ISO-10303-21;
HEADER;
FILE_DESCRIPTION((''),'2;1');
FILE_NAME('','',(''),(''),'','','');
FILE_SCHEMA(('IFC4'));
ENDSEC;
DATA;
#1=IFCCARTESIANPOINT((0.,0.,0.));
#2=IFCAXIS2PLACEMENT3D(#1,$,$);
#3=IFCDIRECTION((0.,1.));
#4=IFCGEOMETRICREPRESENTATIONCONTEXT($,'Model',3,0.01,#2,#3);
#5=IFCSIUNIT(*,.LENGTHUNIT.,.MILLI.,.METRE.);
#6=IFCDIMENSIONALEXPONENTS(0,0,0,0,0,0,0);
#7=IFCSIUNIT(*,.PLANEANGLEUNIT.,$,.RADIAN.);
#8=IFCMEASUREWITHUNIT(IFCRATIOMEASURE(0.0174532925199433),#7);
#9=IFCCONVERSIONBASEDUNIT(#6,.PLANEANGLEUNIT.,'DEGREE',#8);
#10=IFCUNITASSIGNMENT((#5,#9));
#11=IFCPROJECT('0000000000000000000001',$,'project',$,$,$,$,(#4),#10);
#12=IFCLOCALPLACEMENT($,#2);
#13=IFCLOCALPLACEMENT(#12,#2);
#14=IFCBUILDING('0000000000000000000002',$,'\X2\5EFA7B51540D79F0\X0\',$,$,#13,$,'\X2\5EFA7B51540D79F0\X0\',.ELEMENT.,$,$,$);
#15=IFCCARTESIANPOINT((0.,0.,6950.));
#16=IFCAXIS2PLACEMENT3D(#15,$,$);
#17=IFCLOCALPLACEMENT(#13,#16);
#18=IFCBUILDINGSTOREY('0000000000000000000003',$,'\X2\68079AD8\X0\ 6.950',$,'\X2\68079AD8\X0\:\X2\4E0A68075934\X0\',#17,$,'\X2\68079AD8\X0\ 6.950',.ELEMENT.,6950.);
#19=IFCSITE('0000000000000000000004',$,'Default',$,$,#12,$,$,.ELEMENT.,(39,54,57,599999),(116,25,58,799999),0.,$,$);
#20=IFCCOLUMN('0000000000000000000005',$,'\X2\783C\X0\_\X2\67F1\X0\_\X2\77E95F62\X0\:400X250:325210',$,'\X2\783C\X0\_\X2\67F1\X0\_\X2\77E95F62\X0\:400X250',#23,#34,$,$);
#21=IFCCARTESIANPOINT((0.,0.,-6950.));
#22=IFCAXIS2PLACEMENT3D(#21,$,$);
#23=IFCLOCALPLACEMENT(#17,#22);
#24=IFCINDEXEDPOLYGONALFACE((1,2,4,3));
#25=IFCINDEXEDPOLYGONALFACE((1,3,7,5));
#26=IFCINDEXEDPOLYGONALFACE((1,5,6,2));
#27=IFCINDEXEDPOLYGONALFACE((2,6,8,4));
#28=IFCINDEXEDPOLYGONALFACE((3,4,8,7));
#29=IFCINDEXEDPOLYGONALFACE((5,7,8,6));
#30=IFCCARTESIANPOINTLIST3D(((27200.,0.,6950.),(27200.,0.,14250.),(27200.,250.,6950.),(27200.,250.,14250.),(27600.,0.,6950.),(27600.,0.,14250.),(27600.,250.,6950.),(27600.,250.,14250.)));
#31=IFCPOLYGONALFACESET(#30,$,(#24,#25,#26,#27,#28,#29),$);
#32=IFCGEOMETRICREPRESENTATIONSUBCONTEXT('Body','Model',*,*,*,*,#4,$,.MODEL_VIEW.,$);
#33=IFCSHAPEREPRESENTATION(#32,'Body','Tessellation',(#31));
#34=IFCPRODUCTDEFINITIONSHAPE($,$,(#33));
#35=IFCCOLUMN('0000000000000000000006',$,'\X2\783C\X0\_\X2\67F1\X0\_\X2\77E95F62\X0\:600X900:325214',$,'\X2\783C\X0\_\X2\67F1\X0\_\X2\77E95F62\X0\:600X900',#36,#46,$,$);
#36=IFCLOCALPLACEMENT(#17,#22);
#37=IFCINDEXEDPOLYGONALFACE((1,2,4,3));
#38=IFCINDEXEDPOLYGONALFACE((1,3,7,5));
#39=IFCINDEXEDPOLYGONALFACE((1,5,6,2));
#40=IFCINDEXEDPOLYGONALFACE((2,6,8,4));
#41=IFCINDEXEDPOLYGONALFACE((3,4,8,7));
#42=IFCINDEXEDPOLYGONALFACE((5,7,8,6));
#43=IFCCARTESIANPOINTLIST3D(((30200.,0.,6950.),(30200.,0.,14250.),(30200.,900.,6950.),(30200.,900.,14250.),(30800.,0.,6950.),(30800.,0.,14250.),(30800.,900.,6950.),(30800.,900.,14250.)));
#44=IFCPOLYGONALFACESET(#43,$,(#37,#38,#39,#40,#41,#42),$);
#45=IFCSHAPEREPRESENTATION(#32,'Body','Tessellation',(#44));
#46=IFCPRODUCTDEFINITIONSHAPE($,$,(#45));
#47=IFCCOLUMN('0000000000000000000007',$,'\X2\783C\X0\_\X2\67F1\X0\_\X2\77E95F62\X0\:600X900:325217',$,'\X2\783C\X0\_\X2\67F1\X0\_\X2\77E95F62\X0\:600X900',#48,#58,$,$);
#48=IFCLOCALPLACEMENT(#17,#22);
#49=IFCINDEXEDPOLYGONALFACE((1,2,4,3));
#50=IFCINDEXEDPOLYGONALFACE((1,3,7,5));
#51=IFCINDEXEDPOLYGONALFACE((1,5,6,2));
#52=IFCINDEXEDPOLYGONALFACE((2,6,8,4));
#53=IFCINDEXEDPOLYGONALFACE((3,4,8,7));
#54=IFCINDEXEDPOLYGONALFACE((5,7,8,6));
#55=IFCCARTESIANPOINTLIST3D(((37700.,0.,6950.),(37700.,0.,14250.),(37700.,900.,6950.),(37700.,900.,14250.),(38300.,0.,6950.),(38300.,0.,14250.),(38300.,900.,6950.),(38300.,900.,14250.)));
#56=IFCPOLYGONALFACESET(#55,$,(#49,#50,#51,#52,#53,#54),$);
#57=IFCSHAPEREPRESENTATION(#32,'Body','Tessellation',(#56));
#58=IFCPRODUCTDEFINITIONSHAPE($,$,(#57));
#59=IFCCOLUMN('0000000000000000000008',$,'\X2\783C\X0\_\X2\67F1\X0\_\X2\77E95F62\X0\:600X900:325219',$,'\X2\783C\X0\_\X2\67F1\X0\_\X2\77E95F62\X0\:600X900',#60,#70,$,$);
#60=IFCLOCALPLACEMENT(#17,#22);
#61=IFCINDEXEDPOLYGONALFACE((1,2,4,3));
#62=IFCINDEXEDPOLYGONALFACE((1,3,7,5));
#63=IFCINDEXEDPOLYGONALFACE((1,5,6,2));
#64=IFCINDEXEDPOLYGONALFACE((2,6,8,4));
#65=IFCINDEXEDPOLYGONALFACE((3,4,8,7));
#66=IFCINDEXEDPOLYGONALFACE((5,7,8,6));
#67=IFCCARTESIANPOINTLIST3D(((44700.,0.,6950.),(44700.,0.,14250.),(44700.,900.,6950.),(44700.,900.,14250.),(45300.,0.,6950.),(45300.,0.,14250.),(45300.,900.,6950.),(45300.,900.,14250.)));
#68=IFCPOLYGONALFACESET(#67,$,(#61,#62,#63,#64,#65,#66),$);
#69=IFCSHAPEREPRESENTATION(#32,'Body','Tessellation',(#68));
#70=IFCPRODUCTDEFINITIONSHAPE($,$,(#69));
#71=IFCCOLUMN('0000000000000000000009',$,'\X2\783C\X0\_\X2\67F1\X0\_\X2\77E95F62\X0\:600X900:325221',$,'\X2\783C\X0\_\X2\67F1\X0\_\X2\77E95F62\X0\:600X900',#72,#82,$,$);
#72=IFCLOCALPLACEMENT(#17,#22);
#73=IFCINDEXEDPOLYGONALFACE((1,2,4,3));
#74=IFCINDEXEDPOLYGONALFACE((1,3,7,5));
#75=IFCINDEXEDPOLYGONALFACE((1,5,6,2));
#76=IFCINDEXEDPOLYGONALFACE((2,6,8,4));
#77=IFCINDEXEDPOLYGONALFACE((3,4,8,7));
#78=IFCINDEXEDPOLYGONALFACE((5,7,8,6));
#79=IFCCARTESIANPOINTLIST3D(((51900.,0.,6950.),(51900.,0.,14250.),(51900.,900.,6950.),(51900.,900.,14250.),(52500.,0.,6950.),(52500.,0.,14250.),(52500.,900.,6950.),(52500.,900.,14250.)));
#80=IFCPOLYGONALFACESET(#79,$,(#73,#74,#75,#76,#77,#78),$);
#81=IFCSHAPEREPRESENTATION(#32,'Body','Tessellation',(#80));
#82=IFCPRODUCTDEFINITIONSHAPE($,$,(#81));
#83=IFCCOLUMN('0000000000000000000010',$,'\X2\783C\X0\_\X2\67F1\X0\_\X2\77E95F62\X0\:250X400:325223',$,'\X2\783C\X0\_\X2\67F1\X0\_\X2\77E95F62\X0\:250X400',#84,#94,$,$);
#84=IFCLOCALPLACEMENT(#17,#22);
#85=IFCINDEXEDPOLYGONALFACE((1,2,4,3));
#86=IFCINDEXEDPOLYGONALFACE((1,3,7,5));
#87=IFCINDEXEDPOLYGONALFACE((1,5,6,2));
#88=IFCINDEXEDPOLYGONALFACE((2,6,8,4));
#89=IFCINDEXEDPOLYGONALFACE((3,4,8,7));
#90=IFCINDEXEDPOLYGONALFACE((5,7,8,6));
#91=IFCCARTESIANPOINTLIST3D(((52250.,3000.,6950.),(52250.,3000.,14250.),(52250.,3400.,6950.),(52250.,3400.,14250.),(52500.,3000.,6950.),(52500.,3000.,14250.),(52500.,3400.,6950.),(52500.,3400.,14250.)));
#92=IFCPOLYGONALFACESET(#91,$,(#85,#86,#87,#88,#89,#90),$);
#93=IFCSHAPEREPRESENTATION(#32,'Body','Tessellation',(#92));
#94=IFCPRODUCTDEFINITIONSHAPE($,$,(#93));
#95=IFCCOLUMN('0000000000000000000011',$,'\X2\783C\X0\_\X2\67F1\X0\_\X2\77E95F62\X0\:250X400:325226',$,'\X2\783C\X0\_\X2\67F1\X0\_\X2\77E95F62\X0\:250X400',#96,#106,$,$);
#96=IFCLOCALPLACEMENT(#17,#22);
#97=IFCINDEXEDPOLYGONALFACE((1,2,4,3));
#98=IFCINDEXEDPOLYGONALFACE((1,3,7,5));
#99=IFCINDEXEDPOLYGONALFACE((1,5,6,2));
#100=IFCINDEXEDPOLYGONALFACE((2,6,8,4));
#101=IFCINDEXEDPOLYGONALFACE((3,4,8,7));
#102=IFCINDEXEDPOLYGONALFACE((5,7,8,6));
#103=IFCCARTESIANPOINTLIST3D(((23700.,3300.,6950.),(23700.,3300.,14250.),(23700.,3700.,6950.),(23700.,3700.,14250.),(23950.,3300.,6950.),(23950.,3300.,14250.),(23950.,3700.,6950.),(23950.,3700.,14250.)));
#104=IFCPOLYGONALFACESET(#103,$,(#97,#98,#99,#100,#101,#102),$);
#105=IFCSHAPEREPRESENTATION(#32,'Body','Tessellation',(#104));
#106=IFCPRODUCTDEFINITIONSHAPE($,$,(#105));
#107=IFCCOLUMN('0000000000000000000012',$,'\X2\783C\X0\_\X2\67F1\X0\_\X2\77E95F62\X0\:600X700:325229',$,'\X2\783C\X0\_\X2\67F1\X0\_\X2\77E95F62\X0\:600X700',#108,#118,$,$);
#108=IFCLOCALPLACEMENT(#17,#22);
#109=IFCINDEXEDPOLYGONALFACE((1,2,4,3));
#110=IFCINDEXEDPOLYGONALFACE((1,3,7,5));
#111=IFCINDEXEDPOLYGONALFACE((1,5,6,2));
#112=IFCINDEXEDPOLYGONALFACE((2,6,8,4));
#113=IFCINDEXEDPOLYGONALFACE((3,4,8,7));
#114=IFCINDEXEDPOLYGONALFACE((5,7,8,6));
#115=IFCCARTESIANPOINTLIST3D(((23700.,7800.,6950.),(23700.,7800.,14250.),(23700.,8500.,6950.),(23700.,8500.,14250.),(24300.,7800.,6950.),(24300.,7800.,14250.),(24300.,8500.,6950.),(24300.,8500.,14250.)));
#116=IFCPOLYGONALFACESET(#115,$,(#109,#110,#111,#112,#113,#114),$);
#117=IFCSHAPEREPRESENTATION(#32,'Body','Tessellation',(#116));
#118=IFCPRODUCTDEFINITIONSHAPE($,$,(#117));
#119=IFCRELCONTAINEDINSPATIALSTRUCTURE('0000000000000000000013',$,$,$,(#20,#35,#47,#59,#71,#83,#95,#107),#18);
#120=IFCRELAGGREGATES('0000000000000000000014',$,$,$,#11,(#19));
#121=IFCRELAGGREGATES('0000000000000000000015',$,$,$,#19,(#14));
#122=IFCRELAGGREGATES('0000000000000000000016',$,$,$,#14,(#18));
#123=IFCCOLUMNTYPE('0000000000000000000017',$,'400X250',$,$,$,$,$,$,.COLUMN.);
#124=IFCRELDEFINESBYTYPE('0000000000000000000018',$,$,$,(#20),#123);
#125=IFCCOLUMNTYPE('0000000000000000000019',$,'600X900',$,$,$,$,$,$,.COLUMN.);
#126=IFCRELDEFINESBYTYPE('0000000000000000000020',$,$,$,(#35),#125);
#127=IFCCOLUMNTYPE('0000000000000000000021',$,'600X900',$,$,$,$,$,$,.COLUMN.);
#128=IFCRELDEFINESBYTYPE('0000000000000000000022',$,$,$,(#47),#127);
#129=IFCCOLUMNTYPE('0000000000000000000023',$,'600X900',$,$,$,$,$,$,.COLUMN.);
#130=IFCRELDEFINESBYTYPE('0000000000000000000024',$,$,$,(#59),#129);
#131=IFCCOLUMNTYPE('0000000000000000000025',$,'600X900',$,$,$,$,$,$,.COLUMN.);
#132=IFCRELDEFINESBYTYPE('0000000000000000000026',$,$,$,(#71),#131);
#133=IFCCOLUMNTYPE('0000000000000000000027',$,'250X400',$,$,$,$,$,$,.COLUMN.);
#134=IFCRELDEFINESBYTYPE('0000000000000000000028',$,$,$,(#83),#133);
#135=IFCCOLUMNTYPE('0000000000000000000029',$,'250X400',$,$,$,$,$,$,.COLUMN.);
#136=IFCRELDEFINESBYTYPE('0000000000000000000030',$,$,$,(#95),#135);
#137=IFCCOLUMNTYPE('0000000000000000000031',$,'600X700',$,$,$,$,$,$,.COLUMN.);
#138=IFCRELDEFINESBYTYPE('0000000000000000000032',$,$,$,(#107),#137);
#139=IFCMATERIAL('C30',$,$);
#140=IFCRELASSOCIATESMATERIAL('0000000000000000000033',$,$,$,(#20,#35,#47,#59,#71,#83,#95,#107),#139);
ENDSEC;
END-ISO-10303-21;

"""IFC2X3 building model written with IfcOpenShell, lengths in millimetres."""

from ifc_helpers import new_model, entity, si_unit, converted_unit, direction, frame, frame_2d, origin, origin_2d_with_axis, place, context, subcontext, project, spatial, rectangle, extrude, source, transform, mapped, material, type_object, type_shapes, element, save


model = new_model("IFC2X3")

# Units and contexts
model_context = context("Model", 3, precision=0.01, world=origin(), true_north=direction((0.0, 1.0)))
body_context = subcontext(model_context, "Body", "Model", "MODEL_VIEW")
ifc_project = project(units=[si_unit("LENGTHUNIT", "METRE", prefix="MILLI"), converted_unit("PLANEANGLEUNIT", "DEGREE", entity("IfcRatioMeasure", 0.0174532925199433), si_unit("PLANEANGLEUNIT", "RADIAN"), dimensions=[0, 0, 0, 0, 0, 0, 0])], contexts=[model_context])

# Site, building, storey
site_placement = place(None, origin())
site = spatial("IfcSite", under=ifc_project, at=site_placement, Name="Default", CompositionType="ELEMENT", RefLatitude=(39, 54, 57, 599999), RefLongitude=(116, 25, 58, 799999), RefElevation=0.0)
building_placement = place(site_placement, origin())
building = spatial("IfcBuilding", under=site, at=building_placement, Name="建筑名称", LongName="建筑名称", CompositionType="ELEMENT")
storey_placement = place(building_placement, frame((0.0, 0.0, 6950.0)))
storey = spatial("IfcBuildingStorey", under=building, at=storey_placement, Name="标高 6.950", ObjectType="标高:上标头", LongName="标高 6.950", CompositionType="ELEMENT", Elevation=6950.0)

# Columns
ifc_material = material(Name="C30")
column_type_1 = type_object("IfcColumnType", Name="400X250", PredefinedType="COLUMN")
shared_shape_1 = source(origin(), body_context, "Body", "SweptSolid", [
    extrude(rectangle(XDim=250.0, YDim=400.0, at=frame_2d((0.0, 0.0), x_axis=(1.0, 0.0))), frame((27400.0, 125.0, 6950.0), z_axis=(0.0, 0.0, 1.0), x_axis=(0.0, -1.0, 0.0)), (0.0, 0.0, 1.0), 7300.0),
])
type_shapes(column_type_1, [shared_shape_1])
column_1_placement = place(storey_placement, frame((0.0, 0.0, -6950.0)))
element("IfcColumn", 1, at=column_1_placement, inside=storey, type_object=column_type_1, material=ifc_material, Name="砼_柱_矩形:400X250:325210", ObjectType="砼_柱_矩形:400X250", context=body_context, shape_type="MappedRepresentation", body=[
    mapped(shared_shape_1, transform((0.0, 0.0, 0.0), scale=1.0)),
])
column_type_2 = type_object("IfcColumnType", Name="600X900", PredefinedType="COLUMN")
shared_shape_2 = source(origin(), body_context, "Body", "SweptSolid", [
    extrude(rectangle(XDim=900.0, YDim=600.0, at=origin_2d_with_axis()), frame((30500.0, 450.0, 6950.0), z_axis=(0.0, 0.0, 1.0), x_axis=(0.0, -1.0, 0.0)), (0.0, 0.0, 1.0), 7300.0),
])
type_shapes(column_type_2, [shared_shape_2])
column_2_placement = place(storey_placement, frame((0.0, 0.0, -6950.0)))
element("IfcColumn", 2, at=column_2_placement, inside=storey, type_object=column_type_2, material=ifc_material, Name="砼_柱_矩形:600X900:325214", ObjectType="砼_柱_矩形:600X900", context=body_context, shape_type="MappedRepresentation", body=[
    mapped(shared_shape_2, transform((0.0, 0.0, 0.0), scale=1.0)),
])
column_type_3 = type_object("IfcColumnType", Name="600X900", PredefinedType="COLUMN")
shared_shape_3 = source(origin(), body_context, "Body", "SweptSolid", [
    extrude(rectangle(XDim=900.0, YDim=600.0, at=origin_2d_with_axis()), frame((38000.0, 450.0, 6950.0), z_axis=(0.0, 0.0, 1.0), x_axis=(0.0, -1.0, 0.0)), (0.0, 0.0, 1.0), 7300.0),
])
type_shapes(column_type_3, [shared_shape_3])
column_3_placement = place(storey_placement, frame((0.0, 0.0, -6950.0)))
element("IfcColumn", 3, at=column_3_placement, inside=storey, type_object=column_type_3, material=ifc_material, Name="砼_柱_矩形:600X900:325217", ObjectType="砼_柱_矩形:600X900", context=body_context, shape_type="MappedRepresentation", body=[
    mapped(shared_shape_3, transform((0.0, 0.0, 0.0), scale=1.0)),
])
column_type_4 = type_object("IfcColumnType", Name="600X900", PredefinedType="COLUMN")
shared_shape_4 = source(origin(), body_context, "Body", "SweptSolid", [
    extrude(rectangle(XDim=900.0, YDim=600.0, at=origin_2d_with_axis()), frame((45000.0, 450.0, 6950.0), z_axis=(0.0, 0.0, 1.0), x_axis=(0.0, -1.0, 0.0)), (0.0, 0.0, 1.0), 7300.0),
])
type_shapes(column_type_4, [shared_shape_4])
column_4_placement = place(storey_placement, frame((0.0, 0.0, -6950.0)))
element("IfcColumn", 4, at=column_4_placement, inside=storey, type_object=column_type_4, material=ifc_material, Name="砼_柱_矩形:600X900:325219", ObjectType="砼_柱_矩形:600X900", context=body_context, shape_type="MappedRepresentation", body=[
    mapped(shared_shape_4, transform((0.0, 0.0, 0.0), scale=1.0)),
])
column_type_5 = type_object("IfcColumnType", Name="600X900", PredefinedType="COLUMN")
shared_shape_5 = source(origin(), body_context, "Body", "SweptSolid", [
    extrude(rectangle(XDim=900.0, YDim=600.0, at=origin_2d_with_axis()), frame((52200.0, 450.0, 6950.0), z_axis=(0.0, 0.0, 1.0), x_axis=(0.0, -1.0, 0.0)), (0.0, 0.0, 1.0), 7300.0),
])
type_shapes(column_type_5, [shared_shape_5])
column_5_placement = place(storey_placement, frame((0.0, 0.0, -6950.0)))
element("IfcColumn", 5, at=column_5_placement, inside=storey, type_object=column_type_5, material=ifc_material, Name="砼_柱_矩形:600X900:325221", ObjectType="砼_柱_矩形:600X900", context=body_context, shape_type="MappedRepresentation", body=[
    mapped(shared_shape_5, transform((0.0, 0.0, 0.0), scale=1.0)),
])
column_type_6 = type_object("IfcColumnType", Name="250X400", PredefinedType="COLUMN")
shared_shape_6 = source(origin(), body_context, "Body", "SweptSolid", [
    extrude(rectangle(XDim=400.0, YDim=250.0, at=frame_2d((0.0, 0.0), x_axis=(1.0, 0.0))), frame((52375.0, 3200.0, 6950.0), z_axis=(0.0, 0.0, 1.0), x_axis=(0.0, -1.0, 0.0)), (0.0, 0.0, 1.0), 7300.0),
])
type_shapes(column_type_6, [shared_shape_6])
column_6_placement = place(storey_placement, frame((0.0, 0.0, -6950.0)))
element("IfcColumn", 6, at=column_6_placement, inside=storey, type_object=column_type_6, material=ifc_material, Name="砼_柱_矩形:250X400:325223", ObjectType="砼_柱_矩形:250X400", context=body_context, shape_type="MappedRepresentation", body=[
    mapped(shared_shape_6, transform((0.0, 0.0, 0.0), scale=1.0)),
])
column_type_7 = type_object("IfcColumnType", Name="250X400", PredefinedType="COLUMN")
shared_shape_7 = source(origin(), body_context, "Body", "SweptSolid", [
    extrude(rectangle(XDim=400.0, YDim=250.0, at=origin_2d_with_axis()), frame((23825.0, 3500.0, 6950.0), z_axis=(0.0, 0.0, 1.0), x_axis=(0.0, -1.0, 0.0)), (0.0, 0.0, 1.0), 7300.0),
])
type_shapes(column_type_7, [shared_shape_7])
column_7_placement = place(storey_placement, frame((0.0, 0.0, -6950.0)))
element("IfcColumn", 7, at=column_7_placement, inside=storey, type_object=column_type_7, material=ifc_material, Name="砼_柱_矩形:250X400:325226", ObjectType="砼_柱_矩形:250X400", context=body_context, shape_type="MappedRepresentation", body=[
    mapped(shared_shape_7, transform((0.0, 0.0, 0.0), scale=1.0)),
])
column_type_8 = type_object("IfcColumnType", Name="600X700", PredefinedType="COLUMN")
shared_shape_8 = source(origin(), body_context, "Body", "SweptSolid", [
    extrude(rectangle(XDim=700.0, YDim=600.0, at=origin_2d_with_axis()), frame((24000.0, 8150.0, 6950.0), z_axis=(0.0, 0.0, 1.0), x_axis=(0.0, -1.0, 0.0)), (0.0, 0.0, 1.0), 7300.0),
])
type_shapes(column_type_8, [shared_shape_8])
column_8_placement = place(storey_placement, frame((0.0, 0.0, -6950.0)))
element("IfcColumn", 8, at=column_8_placement, inside=storey, type_object=column_type_8, material=ifc_material, Name="砼_柱_矩形:600X700:325229", ObjectType="砼_柱_矩形:600X700", context=body_context, shape_type="MappedRepresentation", body=[
    mapped(shared_shape_8, transform((0.0, 0.0, 0.0), scale=1.0)),
])

save(model, "model.ifc")
